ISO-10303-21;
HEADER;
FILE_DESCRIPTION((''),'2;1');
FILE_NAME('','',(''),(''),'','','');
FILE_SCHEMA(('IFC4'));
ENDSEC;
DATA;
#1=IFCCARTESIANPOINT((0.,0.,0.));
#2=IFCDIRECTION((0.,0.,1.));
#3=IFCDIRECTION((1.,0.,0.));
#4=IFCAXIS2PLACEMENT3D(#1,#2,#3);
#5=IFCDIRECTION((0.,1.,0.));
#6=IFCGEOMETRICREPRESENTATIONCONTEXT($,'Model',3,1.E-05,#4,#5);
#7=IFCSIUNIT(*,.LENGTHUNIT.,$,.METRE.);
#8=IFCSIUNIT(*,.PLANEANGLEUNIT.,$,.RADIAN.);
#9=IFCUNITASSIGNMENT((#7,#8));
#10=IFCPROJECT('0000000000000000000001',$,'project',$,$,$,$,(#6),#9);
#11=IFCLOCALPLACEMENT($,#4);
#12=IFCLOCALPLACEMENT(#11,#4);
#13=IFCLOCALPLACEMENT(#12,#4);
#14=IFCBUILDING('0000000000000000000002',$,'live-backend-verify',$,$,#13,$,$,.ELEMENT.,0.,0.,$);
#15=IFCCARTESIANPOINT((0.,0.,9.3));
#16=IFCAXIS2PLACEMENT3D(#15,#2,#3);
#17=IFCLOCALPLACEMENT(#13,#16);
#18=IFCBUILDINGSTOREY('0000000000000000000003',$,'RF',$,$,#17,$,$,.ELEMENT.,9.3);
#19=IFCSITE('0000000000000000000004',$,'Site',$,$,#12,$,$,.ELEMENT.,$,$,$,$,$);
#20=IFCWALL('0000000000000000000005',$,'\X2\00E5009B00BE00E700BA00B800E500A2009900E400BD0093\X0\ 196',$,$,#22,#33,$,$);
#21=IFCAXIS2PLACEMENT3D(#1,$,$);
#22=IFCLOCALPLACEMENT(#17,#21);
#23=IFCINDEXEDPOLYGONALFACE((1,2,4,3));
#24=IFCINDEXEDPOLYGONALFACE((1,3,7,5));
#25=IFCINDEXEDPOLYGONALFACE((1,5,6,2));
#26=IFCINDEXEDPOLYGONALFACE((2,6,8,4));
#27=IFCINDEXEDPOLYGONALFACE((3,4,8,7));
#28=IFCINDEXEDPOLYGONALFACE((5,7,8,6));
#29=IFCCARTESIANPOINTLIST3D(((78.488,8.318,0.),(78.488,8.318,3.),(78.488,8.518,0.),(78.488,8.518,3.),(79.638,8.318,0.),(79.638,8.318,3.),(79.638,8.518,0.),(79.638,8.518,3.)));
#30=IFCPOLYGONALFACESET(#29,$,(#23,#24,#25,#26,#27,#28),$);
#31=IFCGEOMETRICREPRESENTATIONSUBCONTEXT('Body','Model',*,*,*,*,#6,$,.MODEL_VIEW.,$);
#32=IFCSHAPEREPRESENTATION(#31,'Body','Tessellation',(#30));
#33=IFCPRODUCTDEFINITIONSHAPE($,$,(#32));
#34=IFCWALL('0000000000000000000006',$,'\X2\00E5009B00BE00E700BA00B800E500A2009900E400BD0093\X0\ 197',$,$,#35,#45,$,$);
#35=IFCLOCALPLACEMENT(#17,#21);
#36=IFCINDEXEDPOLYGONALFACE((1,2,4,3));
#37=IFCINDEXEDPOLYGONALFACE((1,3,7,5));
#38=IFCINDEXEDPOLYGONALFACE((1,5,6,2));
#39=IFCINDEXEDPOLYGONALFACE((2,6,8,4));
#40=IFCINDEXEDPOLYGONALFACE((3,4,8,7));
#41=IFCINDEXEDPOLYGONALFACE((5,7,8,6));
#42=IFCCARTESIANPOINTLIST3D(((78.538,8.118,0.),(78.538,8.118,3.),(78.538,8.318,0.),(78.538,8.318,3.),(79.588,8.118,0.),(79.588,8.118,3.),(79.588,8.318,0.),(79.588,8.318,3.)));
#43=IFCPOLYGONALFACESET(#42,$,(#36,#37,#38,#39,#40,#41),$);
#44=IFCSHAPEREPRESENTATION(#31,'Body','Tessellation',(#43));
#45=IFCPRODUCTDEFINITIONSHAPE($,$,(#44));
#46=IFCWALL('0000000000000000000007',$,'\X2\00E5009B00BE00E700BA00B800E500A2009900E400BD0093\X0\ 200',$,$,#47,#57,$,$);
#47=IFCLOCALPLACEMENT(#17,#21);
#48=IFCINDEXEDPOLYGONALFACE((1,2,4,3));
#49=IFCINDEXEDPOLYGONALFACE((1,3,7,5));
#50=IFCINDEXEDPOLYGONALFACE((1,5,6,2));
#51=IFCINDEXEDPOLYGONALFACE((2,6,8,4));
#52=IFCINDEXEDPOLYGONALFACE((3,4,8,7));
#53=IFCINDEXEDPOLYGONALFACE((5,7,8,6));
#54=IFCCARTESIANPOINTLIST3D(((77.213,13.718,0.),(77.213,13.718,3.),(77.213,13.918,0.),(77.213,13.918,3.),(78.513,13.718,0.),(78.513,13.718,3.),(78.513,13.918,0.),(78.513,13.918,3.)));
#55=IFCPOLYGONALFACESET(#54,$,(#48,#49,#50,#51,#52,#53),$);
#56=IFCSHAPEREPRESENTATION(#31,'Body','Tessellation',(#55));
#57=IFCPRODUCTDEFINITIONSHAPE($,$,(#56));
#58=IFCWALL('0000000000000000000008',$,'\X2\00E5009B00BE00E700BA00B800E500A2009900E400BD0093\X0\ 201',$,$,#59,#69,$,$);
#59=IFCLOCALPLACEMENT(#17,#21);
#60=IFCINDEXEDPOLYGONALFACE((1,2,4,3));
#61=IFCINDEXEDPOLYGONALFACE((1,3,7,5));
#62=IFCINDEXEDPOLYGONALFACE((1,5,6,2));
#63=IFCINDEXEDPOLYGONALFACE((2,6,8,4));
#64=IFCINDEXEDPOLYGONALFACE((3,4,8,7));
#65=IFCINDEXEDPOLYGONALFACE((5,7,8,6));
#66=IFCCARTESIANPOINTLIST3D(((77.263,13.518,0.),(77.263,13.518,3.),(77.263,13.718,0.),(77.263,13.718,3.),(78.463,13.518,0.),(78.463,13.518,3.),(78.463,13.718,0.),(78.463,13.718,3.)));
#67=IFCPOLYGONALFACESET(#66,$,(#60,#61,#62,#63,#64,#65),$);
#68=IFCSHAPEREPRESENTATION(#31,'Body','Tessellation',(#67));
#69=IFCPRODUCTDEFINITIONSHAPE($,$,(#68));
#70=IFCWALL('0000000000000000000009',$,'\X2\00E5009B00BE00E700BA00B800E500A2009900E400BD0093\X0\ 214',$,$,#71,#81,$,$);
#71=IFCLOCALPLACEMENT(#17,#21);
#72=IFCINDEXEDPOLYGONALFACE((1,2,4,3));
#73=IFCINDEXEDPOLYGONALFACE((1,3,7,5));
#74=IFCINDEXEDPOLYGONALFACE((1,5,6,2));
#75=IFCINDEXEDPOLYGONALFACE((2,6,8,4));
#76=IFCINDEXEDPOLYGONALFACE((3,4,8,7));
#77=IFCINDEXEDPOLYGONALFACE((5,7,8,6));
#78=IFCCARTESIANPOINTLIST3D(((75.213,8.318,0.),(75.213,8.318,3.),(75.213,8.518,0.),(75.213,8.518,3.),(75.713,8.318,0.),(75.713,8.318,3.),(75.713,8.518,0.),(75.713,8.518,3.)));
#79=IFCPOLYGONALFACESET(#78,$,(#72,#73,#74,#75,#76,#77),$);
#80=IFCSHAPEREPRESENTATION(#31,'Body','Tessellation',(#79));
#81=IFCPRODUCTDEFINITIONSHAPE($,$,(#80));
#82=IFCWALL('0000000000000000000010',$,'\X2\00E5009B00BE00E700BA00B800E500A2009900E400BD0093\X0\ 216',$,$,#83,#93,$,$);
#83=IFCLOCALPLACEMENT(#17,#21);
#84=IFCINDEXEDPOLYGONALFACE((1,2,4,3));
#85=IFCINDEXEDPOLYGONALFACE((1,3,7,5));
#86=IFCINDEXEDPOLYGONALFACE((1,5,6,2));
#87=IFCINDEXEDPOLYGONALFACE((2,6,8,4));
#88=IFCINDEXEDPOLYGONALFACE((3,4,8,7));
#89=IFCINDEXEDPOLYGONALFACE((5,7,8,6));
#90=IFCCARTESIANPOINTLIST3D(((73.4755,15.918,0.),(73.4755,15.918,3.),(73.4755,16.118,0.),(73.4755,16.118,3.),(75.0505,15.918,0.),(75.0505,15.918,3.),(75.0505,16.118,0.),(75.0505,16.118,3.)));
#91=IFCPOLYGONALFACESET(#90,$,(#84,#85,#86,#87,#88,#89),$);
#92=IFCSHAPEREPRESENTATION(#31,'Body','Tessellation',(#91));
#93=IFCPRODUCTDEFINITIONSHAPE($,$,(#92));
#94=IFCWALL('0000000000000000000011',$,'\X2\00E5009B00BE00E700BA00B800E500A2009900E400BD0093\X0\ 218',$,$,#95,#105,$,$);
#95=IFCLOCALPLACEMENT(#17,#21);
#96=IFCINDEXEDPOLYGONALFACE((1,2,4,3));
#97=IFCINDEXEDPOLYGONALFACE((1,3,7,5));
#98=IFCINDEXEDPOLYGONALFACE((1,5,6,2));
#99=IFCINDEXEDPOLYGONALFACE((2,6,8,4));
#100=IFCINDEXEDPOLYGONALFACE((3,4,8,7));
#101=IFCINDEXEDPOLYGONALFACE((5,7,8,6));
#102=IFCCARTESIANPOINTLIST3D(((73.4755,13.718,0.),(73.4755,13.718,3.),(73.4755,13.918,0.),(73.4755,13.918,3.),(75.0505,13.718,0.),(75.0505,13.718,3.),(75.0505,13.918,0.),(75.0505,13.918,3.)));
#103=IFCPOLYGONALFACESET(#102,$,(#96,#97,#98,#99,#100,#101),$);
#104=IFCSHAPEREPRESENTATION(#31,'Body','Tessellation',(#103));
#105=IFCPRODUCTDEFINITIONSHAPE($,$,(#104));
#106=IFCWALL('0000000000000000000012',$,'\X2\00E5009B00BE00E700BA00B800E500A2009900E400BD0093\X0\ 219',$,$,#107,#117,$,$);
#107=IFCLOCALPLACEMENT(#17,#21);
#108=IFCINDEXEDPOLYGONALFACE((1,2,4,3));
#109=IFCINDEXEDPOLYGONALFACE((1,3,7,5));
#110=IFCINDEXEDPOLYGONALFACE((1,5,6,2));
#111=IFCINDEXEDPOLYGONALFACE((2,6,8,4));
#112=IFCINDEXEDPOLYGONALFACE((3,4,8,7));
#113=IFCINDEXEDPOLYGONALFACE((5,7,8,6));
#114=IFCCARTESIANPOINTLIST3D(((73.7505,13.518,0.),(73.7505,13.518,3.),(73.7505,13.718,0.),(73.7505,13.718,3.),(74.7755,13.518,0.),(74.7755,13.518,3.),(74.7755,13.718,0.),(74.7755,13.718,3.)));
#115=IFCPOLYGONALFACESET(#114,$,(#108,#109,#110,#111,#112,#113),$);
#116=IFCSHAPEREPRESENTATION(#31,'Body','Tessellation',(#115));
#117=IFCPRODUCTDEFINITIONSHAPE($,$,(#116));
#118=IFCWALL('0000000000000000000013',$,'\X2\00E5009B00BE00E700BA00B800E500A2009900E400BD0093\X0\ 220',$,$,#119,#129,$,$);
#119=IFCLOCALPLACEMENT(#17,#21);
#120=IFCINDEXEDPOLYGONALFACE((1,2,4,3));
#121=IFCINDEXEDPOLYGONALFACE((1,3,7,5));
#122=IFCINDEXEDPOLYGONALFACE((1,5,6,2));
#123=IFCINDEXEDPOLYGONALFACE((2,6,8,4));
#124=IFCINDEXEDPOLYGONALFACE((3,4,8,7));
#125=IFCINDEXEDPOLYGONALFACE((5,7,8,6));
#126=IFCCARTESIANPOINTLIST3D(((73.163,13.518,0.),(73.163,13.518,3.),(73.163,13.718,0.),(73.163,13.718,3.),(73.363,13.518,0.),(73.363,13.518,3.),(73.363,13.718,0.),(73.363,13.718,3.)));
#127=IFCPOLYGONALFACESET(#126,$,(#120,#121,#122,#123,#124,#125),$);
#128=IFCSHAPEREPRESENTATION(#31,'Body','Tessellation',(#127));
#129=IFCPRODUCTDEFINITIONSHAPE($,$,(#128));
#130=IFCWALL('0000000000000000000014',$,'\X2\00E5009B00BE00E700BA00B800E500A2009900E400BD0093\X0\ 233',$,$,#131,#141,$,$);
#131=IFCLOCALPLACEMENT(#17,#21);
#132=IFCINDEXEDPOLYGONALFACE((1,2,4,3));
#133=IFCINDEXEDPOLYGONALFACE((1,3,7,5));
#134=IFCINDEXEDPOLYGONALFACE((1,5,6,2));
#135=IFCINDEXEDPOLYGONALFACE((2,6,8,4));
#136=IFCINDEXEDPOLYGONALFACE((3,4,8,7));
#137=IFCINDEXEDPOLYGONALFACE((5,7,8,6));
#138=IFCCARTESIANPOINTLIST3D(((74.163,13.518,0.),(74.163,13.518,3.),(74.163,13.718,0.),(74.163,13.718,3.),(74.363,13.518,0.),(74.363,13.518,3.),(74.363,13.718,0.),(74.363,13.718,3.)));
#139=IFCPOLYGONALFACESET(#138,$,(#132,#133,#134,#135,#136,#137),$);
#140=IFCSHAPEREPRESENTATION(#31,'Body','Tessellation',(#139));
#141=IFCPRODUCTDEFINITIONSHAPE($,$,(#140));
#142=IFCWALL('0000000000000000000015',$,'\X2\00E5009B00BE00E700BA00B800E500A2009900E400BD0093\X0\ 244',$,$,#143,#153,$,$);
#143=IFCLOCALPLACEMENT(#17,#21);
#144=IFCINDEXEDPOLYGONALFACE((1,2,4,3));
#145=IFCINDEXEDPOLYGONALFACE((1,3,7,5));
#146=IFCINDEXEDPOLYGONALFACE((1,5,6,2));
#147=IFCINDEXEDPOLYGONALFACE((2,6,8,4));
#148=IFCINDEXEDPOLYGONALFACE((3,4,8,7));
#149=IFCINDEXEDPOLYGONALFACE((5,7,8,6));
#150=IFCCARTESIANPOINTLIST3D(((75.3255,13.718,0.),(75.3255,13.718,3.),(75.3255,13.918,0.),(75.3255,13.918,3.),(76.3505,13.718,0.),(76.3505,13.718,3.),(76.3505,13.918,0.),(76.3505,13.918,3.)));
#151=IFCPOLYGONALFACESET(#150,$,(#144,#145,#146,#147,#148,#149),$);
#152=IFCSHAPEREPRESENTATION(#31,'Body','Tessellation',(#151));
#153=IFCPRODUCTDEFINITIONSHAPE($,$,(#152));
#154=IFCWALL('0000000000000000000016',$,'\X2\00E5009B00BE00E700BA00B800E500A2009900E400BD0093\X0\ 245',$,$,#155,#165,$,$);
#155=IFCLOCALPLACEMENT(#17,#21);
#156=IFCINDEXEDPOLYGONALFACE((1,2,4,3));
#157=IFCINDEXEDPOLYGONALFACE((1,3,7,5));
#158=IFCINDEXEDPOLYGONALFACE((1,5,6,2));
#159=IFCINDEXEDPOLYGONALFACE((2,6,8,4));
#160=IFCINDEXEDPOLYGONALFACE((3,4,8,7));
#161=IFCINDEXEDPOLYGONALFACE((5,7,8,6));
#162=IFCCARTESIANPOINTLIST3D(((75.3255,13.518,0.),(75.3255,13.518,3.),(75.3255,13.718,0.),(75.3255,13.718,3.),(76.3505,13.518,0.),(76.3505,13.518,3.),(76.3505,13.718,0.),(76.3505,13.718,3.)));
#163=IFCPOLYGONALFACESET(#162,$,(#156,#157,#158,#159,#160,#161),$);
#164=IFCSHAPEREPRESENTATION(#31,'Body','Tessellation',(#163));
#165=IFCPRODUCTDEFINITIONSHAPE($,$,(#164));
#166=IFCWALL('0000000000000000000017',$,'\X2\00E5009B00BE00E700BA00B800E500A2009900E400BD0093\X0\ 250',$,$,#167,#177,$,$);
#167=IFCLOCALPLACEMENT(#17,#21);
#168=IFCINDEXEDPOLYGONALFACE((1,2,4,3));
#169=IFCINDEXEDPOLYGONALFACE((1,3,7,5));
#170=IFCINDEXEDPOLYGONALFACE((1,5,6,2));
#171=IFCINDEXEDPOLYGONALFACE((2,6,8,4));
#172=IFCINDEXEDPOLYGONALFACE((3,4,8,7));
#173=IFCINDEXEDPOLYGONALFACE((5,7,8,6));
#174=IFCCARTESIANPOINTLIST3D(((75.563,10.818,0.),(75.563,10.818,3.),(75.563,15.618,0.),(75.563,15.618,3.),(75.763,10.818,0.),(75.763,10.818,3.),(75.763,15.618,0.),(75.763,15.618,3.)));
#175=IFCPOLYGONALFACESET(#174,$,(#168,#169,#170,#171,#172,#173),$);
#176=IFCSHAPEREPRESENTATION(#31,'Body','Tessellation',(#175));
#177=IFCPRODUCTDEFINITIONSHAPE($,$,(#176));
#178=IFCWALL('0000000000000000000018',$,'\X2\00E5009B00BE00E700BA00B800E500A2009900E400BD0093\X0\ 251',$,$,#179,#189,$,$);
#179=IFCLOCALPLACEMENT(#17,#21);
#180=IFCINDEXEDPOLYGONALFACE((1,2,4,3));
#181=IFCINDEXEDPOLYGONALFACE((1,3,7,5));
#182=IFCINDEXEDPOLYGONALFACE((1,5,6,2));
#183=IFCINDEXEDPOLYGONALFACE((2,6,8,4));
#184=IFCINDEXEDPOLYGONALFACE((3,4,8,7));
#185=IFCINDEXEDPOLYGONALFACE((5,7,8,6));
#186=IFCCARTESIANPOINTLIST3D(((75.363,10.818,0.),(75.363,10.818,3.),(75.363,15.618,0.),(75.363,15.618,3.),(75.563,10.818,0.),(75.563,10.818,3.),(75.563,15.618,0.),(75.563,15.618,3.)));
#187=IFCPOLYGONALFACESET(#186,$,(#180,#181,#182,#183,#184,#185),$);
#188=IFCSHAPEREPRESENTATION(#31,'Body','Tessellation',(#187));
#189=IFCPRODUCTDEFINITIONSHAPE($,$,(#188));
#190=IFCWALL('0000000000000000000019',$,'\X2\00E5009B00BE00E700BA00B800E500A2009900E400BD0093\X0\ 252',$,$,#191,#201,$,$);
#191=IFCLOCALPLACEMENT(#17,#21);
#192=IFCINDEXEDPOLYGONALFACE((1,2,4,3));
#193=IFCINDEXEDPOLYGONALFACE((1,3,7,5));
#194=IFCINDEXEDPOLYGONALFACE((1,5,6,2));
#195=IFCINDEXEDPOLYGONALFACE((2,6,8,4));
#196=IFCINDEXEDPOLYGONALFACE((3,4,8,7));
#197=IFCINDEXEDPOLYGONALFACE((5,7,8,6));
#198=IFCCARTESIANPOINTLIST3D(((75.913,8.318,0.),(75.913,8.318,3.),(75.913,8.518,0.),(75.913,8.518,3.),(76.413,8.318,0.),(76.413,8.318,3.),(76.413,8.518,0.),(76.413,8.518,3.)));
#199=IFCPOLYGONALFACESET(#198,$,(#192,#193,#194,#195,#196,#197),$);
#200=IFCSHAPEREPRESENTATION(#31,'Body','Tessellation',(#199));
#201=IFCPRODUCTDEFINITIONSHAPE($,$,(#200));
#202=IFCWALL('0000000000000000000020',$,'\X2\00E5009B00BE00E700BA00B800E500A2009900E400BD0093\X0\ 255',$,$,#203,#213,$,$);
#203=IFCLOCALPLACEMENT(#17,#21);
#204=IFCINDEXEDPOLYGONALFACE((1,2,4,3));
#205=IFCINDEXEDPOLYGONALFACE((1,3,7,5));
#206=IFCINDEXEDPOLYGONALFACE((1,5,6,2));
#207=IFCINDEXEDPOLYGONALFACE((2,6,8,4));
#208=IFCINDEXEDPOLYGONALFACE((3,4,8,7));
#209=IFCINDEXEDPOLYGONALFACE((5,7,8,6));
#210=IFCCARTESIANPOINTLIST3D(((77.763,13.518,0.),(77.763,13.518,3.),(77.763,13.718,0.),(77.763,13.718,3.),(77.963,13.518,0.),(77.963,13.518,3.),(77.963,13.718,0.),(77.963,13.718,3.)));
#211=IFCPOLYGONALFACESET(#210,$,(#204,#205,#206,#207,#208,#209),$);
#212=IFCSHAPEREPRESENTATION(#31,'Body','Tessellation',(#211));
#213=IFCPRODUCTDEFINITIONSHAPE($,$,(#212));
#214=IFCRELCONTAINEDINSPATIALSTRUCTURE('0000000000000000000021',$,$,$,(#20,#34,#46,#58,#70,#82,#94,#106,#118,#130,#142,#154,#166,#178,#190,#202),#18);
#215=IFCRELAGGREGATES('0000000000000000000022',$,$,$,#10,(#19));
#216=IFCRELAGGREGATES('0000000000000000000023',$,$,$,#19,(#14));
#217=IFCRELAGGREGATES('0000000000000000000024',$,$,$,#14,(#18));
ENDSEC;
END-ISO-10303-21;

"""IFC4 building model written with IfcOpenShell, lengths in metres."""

from ifc_helpers import new_model, si_unit, direction, frame, frame_2d, origin_with_axes, place, context, subcontext, project, spatial, rectangle, extrude, element, save


model = new_model("IFC4")

# Units and contexts
model_context = context("Model", 3, precision=1e-05, world=origin_with_axes(), true_north=direction((0.0, 1.0, 0.0)))
body_context = subcontext(model_context, "Body", "Model", "MODEL_VIEW")
ifc_project = project(units=[si_unit("LENGTHUNIT", "METRE"), si_unit("PLANEANGLEUNIT", "RADIAN")], contexts=[model_context])

# Site, building, storey
placement = place(None, origin_with_axes())
site_placement = place(placement, origin_with_axes())
site = spatial("IfcSite", under=ifc_project, at=site_placement, Name="Site", CompositionType="ELEMENT")
building_placement = place(site_placement, origin_with_axes())
building = spatial("IfcBuilding", under=site, at=building_placement, Name="live-backend-verify", CompositionType="ELEMENT", ElevationOfRefHeight=0.0, ElevationOfTerrain=0.0)
storey_placement = place(building_placement, frame((0.0, 0.0, 9.3), z_axis=(0.0, 0.0, 1.0), x_axis=(1.0, 0.0, 0.0)))
storey = spatial("IfcBuildingStorey", under=building, at=storey_placement, Name="RF", CompositionType="ELEMENT", Elevation=9.3)

# Walls
wall_1_placement = place(storey_placement, frame((79.063, 8.418, 0.0), z_axis=(0.0, 0.0, 1.0), x_axis=(-1.0, 0.0, 0.0)))
element("IfcWall", 1, at=wall_1_placement, inside=storey, Name="å\u009b¾çº¸å¢\u0099ä½\u0093 196", context=body_context, shape_type="SweptSolid", body=[
    extrude(rectangle(XDim=1.15, YDim=0.2, at=frame_2d((0.0, 0.0), x_axis=(1.0, 0.0, 0.0))), frame((0.0, 0.0, 0.0), z_axis=(0.0, 0.0, 1.0)), (0.0, 0.0, 1.0), 3.0),
])
wall_2_placement = place(storey_placement, frame((79.063, 8.218, 0.0), z_axis=(0.0, 0.0, 1.0), x_axis=(-1.0, 0.0, 0.0)))
element("IfcWall", 2, at=wall_2_placement, inside=storey, Name="å\u009b¾çº¸å¢\u0099ä½\u0093 197", context=body_context, shape_type="SweptSolid", body=[
    extrude(rectangle(XDim=1.05, YDim=0.2, at=frame_2d((0.0, 0.0), x_axis=(1.0, 0.0, 0.0))), frame((0.0, 0.0, 0.0), z_axis=(0.0, 0.0, 1.0)), (0.0, 0.0, 1.0), 3.0),
])
wall_3_placement = place(storey_placement, frame((77.863, 13.818, 0.0), z_axis=(0.0, 0.0, 1.0), x_axis=(1.0, 0.0, 0.0)))
element("IfcWall", 3, at=wall_3_placement, inside=storey, Name="å\u009b¾çº¸å¢\u0099ä½\u0093 200", context=body_context, shape_type="SweptSolid", body=[
    extrude(rectangle(XDim=1.3, YDim=0.2, at=frame_2d((0.0, 0.0), x_axis=(1.0, 0.0, 0.0))), frame((0.0, 0.0, 0.0), z_axis=(0.0, 0.0, 1.0)), (0.0, 0.0, 1.0), 3.0),
])
wall_4_placement = place(storey_placement, frame((77.863, 13.618, 0.0), z_axis=(0.0, 0.0, 1.0), x_axis=(1.0, 0.0, 0.0)))
element("IfcWall", 4, at=wall_4_placement, inside=storey, Name="å\u009b¾çº¸å¢\u0099ä½\u0093 201", context=body_context, shape_type="SweptSolid", body=[
    extrude(rectangle(XDim=1.2, YDim=0.2, at=frame_2d((0.0, 0.0), x_axis=(1.0, 0.0, 0.0))), frame((0.0, 0.0, 0.0), z_axis=(0.0, 0.0, 1.0)), (0.0, 0.0, 1.0), 3.0),
])
wall_5_placement = place(storey_placement, frame((75.463, 8.418, 0.0), z_axis=(0.0, 0.0, 1.0), x_axis=(-1.0, 0.0, 0.0)))
element("IfcWall", 5, at=wall_5_placement, inside=storey, Name="å\u009b¾çº¸å¢\u0099ä½\u0093 214", context=body_context, shape_type="SweptSolid", body=[
    extrude(rectangle(XDim=0.5, YDim=0.2, at=frame_2d((0.0, 0.0), x_axis=(1.0, 0.0, 0.0))), frame((0.0, 0.0, 0.0), z_axis=(0.0, 0.0, 1.0)), (0.0, 0.0, 1.0), 3.0),
])
for number, where, z_axis, x_axis, name in (
    (6, (74.263, 16.018, 0.0), (0.0, 0.0, 1.0), (1.0, 0.0, 0.0), "å\u009b¾çº¸å¢\u0099ä½\u0093 216"),
    (7, (74.263, 13.818, 0.0), (0.0, 0.0, 1.0), (1.0, 0.0, 0.0), "å\u009b¾çº¸å¢\u0099ä½\u0093 218"),
):
    element("IfcWall", number, at=place(storey_placement, frame(where, z_axis=z_axis, x_axis=x_axis)), inside=storey, Name=name, context=body_context, shape_type="SweptSolid", body=[
        extrude(rectangle(XDim=1.575, YDim=0.2, at=frame_2d((0.0, 0.0), x_axis=(1.0, 0.0, 0.0))), frame((0.0, 0.0, 0.0), z_axis=(0.0, 0.0, 1.0)), (0.0, 0.0, 1.0), 3.0),
    ])
wall_6_placement = place(storey_placement, frame((74.263, 13.618, 0.0), z_axis=(0.0, 0.0, 1.0), x_axis=(1.0, 0.0, 0.0)))
element("IfcWall", 8, at=wall_6_placement, inside=storey, Name="å\u009b¾çº¸å¢\u0099ä½\u0093 219", context=body_context, shape_type="SweptSolid", body=[
    extrude(rectangle(XDim=1.025, YDim=0.2, at=frame_2d((0.0, 0.0), x_axis=(1.0, 0.0, 0.0))), frame((0.0, 0.0, 0.0), z_axis=(0.0, 0.0, 1.0)), (0.0, 0.0, 1.0), 3.0),
])
for number, where, z_axis, x_axis, name in (
    (9, (73.263, 13.618, 0.0), (0.0, 0.0, 1.0), (0.0, 1.0, 0.0), "å\u009b¾çº¸å¢\u0099ä½\u0093 220"),
    (10, (74.263, 13.618, 0.0), (0.0, 0.0, 1.0), (0.0, 1.0, 0.0), "å\u009b¾çº¸å¢\u0099ä½\u0093 233"),
):
    element("IfcWall", number, at=place(storey_placement, frame(where, z_axis=z_axis, x_axis=x_axis)), inside=storey, Name=name, context=body_context, shape_type="SweptSolid", body=[
        extrude(rectangle(XDim=0.2, YDim=0.2, at=frame_2d((0.0, 0.0), x_axis=(1.0, 0.0, 0.0))), frame((0.0, 0.0, 0.0), z_axis=(0.0, 0.0, 1.0)), (0.0, 0.0, 1.0), 3.0),
    ])
for number, where, z_axis, x_axis, name in (
    (11, (75.838, 13.818, 0.0), (0.0, 0.0, 1.0), (1.0, 0.0, 0.0), "å\u009b¾çº¸å¢\u0099ä½\u0093 244"),
    (12, (75.838, 13.618, 0.0), (0.0, 0.0, 1.0), (1.0, 0.0, 0.0), "å\u009b¾çº¸å¢\u0099ä½\u0093 245"),
):
    element("IfcWall", number, at=place(storey_placement, frame(where, z_axis=z_axis, x_axis=x_axis)), inside=storey, Name=name, context=body_context, shape_type="SweptSolid", body=[
        extrude(rectangle(XDim=1.025, YDim=0.2, at=frame_2d((0.0, 0.0), x_axis=(1.0, 0.0, 0.0))), frame((0.0, 0.0, 0.0), z_axis=(0.0, 0.0, 1.0)), (0.0, 0.0, 1.0), 3.0),
    ])
for number, where, z_axis, x_axis, name in (
    (13, (75.663, 13.218, 0.0), (0.0, 0.0, 1.0), (0.0, -1.0, 0.0), "å\u009b¾çº¸å¢\u0099ä½\u0093 250"),
    (14, (75.463, 13.218, 0.0), (0.0, 0.0, 1.0), (0.0, -1.0, 0.0), "å\u009b¾çº¸å¢\u0099ä½\u0093 251"),
):
    element("IfcWall", number, at=place(storey_placement, frame(where, z_axis=z_axis, x_axis=x_axis)), inside=storey, Name=name, context=body_context, shape_type="SweptSolid", body=[
        extrude(rectangle(XDim=4.8, YDim=0.2, at=frame_2d((0.0, 0.0), x_axis=(1.0, 0.0, 0.0))), frame((0.0, 0.0, 0.0), z_axis=(0.0, 0.0, 1.0)), (0.0, 0.0, 1.0), 3.0),
    ])
wall_7_placement = place(storey_placement, frame((76.163, 8.418, 0.0), z_axis=(0.0, 0.0, 1.0), x_axis=(-1.0, 0.0, 0.0)))
element("IfcWall", 15, at=wall_7_placement, inside=storey, Name="å\u009b¾çº¸å¢\u0099ä½\u0093 252", context=body_context, shape_type="SweptSolid", body=[
    extrude(rectangle(XDim=0.5, YDim=0.2, at=frame_2d((0.0, 0.0), x_axis=(1.0, 0.0, 0.0))), frame((0.0, 0.0, 0.0), z_axis=(0.0, 0.0, 1.0)), (0.0, 0.0, 1.0), 3.0),
])
for number, where, z_axis, x_axis, name in (
    (16, (77.863, 13.618, 0.0), (0.0, 0.0, 1.0), (0.0, 1.0, 0.0), "å\u009b¾çº¸å¢\u0099ä½\u0093 255"),
):
    element("IfcWall", number, at=place(storey_placement, frame(where, z_axis=z_axis, x_axis=x_axis)), inside=storey, Name=name, context=body_context, shape_type="SweptSolid", body=[
        extrude(rectangle(XDim=0.2, YDim=0.2, at=frame_2d((0.0, 0.0), x_axis=(1.0, 0.0, 0.0))), frame((0.0, 0.0, 0.0), z_axis=(0.0, 0.0, 1.0)), (0.0, 0.0, 1.0), 3.0),
    ])

save(model, "model.ifc")
